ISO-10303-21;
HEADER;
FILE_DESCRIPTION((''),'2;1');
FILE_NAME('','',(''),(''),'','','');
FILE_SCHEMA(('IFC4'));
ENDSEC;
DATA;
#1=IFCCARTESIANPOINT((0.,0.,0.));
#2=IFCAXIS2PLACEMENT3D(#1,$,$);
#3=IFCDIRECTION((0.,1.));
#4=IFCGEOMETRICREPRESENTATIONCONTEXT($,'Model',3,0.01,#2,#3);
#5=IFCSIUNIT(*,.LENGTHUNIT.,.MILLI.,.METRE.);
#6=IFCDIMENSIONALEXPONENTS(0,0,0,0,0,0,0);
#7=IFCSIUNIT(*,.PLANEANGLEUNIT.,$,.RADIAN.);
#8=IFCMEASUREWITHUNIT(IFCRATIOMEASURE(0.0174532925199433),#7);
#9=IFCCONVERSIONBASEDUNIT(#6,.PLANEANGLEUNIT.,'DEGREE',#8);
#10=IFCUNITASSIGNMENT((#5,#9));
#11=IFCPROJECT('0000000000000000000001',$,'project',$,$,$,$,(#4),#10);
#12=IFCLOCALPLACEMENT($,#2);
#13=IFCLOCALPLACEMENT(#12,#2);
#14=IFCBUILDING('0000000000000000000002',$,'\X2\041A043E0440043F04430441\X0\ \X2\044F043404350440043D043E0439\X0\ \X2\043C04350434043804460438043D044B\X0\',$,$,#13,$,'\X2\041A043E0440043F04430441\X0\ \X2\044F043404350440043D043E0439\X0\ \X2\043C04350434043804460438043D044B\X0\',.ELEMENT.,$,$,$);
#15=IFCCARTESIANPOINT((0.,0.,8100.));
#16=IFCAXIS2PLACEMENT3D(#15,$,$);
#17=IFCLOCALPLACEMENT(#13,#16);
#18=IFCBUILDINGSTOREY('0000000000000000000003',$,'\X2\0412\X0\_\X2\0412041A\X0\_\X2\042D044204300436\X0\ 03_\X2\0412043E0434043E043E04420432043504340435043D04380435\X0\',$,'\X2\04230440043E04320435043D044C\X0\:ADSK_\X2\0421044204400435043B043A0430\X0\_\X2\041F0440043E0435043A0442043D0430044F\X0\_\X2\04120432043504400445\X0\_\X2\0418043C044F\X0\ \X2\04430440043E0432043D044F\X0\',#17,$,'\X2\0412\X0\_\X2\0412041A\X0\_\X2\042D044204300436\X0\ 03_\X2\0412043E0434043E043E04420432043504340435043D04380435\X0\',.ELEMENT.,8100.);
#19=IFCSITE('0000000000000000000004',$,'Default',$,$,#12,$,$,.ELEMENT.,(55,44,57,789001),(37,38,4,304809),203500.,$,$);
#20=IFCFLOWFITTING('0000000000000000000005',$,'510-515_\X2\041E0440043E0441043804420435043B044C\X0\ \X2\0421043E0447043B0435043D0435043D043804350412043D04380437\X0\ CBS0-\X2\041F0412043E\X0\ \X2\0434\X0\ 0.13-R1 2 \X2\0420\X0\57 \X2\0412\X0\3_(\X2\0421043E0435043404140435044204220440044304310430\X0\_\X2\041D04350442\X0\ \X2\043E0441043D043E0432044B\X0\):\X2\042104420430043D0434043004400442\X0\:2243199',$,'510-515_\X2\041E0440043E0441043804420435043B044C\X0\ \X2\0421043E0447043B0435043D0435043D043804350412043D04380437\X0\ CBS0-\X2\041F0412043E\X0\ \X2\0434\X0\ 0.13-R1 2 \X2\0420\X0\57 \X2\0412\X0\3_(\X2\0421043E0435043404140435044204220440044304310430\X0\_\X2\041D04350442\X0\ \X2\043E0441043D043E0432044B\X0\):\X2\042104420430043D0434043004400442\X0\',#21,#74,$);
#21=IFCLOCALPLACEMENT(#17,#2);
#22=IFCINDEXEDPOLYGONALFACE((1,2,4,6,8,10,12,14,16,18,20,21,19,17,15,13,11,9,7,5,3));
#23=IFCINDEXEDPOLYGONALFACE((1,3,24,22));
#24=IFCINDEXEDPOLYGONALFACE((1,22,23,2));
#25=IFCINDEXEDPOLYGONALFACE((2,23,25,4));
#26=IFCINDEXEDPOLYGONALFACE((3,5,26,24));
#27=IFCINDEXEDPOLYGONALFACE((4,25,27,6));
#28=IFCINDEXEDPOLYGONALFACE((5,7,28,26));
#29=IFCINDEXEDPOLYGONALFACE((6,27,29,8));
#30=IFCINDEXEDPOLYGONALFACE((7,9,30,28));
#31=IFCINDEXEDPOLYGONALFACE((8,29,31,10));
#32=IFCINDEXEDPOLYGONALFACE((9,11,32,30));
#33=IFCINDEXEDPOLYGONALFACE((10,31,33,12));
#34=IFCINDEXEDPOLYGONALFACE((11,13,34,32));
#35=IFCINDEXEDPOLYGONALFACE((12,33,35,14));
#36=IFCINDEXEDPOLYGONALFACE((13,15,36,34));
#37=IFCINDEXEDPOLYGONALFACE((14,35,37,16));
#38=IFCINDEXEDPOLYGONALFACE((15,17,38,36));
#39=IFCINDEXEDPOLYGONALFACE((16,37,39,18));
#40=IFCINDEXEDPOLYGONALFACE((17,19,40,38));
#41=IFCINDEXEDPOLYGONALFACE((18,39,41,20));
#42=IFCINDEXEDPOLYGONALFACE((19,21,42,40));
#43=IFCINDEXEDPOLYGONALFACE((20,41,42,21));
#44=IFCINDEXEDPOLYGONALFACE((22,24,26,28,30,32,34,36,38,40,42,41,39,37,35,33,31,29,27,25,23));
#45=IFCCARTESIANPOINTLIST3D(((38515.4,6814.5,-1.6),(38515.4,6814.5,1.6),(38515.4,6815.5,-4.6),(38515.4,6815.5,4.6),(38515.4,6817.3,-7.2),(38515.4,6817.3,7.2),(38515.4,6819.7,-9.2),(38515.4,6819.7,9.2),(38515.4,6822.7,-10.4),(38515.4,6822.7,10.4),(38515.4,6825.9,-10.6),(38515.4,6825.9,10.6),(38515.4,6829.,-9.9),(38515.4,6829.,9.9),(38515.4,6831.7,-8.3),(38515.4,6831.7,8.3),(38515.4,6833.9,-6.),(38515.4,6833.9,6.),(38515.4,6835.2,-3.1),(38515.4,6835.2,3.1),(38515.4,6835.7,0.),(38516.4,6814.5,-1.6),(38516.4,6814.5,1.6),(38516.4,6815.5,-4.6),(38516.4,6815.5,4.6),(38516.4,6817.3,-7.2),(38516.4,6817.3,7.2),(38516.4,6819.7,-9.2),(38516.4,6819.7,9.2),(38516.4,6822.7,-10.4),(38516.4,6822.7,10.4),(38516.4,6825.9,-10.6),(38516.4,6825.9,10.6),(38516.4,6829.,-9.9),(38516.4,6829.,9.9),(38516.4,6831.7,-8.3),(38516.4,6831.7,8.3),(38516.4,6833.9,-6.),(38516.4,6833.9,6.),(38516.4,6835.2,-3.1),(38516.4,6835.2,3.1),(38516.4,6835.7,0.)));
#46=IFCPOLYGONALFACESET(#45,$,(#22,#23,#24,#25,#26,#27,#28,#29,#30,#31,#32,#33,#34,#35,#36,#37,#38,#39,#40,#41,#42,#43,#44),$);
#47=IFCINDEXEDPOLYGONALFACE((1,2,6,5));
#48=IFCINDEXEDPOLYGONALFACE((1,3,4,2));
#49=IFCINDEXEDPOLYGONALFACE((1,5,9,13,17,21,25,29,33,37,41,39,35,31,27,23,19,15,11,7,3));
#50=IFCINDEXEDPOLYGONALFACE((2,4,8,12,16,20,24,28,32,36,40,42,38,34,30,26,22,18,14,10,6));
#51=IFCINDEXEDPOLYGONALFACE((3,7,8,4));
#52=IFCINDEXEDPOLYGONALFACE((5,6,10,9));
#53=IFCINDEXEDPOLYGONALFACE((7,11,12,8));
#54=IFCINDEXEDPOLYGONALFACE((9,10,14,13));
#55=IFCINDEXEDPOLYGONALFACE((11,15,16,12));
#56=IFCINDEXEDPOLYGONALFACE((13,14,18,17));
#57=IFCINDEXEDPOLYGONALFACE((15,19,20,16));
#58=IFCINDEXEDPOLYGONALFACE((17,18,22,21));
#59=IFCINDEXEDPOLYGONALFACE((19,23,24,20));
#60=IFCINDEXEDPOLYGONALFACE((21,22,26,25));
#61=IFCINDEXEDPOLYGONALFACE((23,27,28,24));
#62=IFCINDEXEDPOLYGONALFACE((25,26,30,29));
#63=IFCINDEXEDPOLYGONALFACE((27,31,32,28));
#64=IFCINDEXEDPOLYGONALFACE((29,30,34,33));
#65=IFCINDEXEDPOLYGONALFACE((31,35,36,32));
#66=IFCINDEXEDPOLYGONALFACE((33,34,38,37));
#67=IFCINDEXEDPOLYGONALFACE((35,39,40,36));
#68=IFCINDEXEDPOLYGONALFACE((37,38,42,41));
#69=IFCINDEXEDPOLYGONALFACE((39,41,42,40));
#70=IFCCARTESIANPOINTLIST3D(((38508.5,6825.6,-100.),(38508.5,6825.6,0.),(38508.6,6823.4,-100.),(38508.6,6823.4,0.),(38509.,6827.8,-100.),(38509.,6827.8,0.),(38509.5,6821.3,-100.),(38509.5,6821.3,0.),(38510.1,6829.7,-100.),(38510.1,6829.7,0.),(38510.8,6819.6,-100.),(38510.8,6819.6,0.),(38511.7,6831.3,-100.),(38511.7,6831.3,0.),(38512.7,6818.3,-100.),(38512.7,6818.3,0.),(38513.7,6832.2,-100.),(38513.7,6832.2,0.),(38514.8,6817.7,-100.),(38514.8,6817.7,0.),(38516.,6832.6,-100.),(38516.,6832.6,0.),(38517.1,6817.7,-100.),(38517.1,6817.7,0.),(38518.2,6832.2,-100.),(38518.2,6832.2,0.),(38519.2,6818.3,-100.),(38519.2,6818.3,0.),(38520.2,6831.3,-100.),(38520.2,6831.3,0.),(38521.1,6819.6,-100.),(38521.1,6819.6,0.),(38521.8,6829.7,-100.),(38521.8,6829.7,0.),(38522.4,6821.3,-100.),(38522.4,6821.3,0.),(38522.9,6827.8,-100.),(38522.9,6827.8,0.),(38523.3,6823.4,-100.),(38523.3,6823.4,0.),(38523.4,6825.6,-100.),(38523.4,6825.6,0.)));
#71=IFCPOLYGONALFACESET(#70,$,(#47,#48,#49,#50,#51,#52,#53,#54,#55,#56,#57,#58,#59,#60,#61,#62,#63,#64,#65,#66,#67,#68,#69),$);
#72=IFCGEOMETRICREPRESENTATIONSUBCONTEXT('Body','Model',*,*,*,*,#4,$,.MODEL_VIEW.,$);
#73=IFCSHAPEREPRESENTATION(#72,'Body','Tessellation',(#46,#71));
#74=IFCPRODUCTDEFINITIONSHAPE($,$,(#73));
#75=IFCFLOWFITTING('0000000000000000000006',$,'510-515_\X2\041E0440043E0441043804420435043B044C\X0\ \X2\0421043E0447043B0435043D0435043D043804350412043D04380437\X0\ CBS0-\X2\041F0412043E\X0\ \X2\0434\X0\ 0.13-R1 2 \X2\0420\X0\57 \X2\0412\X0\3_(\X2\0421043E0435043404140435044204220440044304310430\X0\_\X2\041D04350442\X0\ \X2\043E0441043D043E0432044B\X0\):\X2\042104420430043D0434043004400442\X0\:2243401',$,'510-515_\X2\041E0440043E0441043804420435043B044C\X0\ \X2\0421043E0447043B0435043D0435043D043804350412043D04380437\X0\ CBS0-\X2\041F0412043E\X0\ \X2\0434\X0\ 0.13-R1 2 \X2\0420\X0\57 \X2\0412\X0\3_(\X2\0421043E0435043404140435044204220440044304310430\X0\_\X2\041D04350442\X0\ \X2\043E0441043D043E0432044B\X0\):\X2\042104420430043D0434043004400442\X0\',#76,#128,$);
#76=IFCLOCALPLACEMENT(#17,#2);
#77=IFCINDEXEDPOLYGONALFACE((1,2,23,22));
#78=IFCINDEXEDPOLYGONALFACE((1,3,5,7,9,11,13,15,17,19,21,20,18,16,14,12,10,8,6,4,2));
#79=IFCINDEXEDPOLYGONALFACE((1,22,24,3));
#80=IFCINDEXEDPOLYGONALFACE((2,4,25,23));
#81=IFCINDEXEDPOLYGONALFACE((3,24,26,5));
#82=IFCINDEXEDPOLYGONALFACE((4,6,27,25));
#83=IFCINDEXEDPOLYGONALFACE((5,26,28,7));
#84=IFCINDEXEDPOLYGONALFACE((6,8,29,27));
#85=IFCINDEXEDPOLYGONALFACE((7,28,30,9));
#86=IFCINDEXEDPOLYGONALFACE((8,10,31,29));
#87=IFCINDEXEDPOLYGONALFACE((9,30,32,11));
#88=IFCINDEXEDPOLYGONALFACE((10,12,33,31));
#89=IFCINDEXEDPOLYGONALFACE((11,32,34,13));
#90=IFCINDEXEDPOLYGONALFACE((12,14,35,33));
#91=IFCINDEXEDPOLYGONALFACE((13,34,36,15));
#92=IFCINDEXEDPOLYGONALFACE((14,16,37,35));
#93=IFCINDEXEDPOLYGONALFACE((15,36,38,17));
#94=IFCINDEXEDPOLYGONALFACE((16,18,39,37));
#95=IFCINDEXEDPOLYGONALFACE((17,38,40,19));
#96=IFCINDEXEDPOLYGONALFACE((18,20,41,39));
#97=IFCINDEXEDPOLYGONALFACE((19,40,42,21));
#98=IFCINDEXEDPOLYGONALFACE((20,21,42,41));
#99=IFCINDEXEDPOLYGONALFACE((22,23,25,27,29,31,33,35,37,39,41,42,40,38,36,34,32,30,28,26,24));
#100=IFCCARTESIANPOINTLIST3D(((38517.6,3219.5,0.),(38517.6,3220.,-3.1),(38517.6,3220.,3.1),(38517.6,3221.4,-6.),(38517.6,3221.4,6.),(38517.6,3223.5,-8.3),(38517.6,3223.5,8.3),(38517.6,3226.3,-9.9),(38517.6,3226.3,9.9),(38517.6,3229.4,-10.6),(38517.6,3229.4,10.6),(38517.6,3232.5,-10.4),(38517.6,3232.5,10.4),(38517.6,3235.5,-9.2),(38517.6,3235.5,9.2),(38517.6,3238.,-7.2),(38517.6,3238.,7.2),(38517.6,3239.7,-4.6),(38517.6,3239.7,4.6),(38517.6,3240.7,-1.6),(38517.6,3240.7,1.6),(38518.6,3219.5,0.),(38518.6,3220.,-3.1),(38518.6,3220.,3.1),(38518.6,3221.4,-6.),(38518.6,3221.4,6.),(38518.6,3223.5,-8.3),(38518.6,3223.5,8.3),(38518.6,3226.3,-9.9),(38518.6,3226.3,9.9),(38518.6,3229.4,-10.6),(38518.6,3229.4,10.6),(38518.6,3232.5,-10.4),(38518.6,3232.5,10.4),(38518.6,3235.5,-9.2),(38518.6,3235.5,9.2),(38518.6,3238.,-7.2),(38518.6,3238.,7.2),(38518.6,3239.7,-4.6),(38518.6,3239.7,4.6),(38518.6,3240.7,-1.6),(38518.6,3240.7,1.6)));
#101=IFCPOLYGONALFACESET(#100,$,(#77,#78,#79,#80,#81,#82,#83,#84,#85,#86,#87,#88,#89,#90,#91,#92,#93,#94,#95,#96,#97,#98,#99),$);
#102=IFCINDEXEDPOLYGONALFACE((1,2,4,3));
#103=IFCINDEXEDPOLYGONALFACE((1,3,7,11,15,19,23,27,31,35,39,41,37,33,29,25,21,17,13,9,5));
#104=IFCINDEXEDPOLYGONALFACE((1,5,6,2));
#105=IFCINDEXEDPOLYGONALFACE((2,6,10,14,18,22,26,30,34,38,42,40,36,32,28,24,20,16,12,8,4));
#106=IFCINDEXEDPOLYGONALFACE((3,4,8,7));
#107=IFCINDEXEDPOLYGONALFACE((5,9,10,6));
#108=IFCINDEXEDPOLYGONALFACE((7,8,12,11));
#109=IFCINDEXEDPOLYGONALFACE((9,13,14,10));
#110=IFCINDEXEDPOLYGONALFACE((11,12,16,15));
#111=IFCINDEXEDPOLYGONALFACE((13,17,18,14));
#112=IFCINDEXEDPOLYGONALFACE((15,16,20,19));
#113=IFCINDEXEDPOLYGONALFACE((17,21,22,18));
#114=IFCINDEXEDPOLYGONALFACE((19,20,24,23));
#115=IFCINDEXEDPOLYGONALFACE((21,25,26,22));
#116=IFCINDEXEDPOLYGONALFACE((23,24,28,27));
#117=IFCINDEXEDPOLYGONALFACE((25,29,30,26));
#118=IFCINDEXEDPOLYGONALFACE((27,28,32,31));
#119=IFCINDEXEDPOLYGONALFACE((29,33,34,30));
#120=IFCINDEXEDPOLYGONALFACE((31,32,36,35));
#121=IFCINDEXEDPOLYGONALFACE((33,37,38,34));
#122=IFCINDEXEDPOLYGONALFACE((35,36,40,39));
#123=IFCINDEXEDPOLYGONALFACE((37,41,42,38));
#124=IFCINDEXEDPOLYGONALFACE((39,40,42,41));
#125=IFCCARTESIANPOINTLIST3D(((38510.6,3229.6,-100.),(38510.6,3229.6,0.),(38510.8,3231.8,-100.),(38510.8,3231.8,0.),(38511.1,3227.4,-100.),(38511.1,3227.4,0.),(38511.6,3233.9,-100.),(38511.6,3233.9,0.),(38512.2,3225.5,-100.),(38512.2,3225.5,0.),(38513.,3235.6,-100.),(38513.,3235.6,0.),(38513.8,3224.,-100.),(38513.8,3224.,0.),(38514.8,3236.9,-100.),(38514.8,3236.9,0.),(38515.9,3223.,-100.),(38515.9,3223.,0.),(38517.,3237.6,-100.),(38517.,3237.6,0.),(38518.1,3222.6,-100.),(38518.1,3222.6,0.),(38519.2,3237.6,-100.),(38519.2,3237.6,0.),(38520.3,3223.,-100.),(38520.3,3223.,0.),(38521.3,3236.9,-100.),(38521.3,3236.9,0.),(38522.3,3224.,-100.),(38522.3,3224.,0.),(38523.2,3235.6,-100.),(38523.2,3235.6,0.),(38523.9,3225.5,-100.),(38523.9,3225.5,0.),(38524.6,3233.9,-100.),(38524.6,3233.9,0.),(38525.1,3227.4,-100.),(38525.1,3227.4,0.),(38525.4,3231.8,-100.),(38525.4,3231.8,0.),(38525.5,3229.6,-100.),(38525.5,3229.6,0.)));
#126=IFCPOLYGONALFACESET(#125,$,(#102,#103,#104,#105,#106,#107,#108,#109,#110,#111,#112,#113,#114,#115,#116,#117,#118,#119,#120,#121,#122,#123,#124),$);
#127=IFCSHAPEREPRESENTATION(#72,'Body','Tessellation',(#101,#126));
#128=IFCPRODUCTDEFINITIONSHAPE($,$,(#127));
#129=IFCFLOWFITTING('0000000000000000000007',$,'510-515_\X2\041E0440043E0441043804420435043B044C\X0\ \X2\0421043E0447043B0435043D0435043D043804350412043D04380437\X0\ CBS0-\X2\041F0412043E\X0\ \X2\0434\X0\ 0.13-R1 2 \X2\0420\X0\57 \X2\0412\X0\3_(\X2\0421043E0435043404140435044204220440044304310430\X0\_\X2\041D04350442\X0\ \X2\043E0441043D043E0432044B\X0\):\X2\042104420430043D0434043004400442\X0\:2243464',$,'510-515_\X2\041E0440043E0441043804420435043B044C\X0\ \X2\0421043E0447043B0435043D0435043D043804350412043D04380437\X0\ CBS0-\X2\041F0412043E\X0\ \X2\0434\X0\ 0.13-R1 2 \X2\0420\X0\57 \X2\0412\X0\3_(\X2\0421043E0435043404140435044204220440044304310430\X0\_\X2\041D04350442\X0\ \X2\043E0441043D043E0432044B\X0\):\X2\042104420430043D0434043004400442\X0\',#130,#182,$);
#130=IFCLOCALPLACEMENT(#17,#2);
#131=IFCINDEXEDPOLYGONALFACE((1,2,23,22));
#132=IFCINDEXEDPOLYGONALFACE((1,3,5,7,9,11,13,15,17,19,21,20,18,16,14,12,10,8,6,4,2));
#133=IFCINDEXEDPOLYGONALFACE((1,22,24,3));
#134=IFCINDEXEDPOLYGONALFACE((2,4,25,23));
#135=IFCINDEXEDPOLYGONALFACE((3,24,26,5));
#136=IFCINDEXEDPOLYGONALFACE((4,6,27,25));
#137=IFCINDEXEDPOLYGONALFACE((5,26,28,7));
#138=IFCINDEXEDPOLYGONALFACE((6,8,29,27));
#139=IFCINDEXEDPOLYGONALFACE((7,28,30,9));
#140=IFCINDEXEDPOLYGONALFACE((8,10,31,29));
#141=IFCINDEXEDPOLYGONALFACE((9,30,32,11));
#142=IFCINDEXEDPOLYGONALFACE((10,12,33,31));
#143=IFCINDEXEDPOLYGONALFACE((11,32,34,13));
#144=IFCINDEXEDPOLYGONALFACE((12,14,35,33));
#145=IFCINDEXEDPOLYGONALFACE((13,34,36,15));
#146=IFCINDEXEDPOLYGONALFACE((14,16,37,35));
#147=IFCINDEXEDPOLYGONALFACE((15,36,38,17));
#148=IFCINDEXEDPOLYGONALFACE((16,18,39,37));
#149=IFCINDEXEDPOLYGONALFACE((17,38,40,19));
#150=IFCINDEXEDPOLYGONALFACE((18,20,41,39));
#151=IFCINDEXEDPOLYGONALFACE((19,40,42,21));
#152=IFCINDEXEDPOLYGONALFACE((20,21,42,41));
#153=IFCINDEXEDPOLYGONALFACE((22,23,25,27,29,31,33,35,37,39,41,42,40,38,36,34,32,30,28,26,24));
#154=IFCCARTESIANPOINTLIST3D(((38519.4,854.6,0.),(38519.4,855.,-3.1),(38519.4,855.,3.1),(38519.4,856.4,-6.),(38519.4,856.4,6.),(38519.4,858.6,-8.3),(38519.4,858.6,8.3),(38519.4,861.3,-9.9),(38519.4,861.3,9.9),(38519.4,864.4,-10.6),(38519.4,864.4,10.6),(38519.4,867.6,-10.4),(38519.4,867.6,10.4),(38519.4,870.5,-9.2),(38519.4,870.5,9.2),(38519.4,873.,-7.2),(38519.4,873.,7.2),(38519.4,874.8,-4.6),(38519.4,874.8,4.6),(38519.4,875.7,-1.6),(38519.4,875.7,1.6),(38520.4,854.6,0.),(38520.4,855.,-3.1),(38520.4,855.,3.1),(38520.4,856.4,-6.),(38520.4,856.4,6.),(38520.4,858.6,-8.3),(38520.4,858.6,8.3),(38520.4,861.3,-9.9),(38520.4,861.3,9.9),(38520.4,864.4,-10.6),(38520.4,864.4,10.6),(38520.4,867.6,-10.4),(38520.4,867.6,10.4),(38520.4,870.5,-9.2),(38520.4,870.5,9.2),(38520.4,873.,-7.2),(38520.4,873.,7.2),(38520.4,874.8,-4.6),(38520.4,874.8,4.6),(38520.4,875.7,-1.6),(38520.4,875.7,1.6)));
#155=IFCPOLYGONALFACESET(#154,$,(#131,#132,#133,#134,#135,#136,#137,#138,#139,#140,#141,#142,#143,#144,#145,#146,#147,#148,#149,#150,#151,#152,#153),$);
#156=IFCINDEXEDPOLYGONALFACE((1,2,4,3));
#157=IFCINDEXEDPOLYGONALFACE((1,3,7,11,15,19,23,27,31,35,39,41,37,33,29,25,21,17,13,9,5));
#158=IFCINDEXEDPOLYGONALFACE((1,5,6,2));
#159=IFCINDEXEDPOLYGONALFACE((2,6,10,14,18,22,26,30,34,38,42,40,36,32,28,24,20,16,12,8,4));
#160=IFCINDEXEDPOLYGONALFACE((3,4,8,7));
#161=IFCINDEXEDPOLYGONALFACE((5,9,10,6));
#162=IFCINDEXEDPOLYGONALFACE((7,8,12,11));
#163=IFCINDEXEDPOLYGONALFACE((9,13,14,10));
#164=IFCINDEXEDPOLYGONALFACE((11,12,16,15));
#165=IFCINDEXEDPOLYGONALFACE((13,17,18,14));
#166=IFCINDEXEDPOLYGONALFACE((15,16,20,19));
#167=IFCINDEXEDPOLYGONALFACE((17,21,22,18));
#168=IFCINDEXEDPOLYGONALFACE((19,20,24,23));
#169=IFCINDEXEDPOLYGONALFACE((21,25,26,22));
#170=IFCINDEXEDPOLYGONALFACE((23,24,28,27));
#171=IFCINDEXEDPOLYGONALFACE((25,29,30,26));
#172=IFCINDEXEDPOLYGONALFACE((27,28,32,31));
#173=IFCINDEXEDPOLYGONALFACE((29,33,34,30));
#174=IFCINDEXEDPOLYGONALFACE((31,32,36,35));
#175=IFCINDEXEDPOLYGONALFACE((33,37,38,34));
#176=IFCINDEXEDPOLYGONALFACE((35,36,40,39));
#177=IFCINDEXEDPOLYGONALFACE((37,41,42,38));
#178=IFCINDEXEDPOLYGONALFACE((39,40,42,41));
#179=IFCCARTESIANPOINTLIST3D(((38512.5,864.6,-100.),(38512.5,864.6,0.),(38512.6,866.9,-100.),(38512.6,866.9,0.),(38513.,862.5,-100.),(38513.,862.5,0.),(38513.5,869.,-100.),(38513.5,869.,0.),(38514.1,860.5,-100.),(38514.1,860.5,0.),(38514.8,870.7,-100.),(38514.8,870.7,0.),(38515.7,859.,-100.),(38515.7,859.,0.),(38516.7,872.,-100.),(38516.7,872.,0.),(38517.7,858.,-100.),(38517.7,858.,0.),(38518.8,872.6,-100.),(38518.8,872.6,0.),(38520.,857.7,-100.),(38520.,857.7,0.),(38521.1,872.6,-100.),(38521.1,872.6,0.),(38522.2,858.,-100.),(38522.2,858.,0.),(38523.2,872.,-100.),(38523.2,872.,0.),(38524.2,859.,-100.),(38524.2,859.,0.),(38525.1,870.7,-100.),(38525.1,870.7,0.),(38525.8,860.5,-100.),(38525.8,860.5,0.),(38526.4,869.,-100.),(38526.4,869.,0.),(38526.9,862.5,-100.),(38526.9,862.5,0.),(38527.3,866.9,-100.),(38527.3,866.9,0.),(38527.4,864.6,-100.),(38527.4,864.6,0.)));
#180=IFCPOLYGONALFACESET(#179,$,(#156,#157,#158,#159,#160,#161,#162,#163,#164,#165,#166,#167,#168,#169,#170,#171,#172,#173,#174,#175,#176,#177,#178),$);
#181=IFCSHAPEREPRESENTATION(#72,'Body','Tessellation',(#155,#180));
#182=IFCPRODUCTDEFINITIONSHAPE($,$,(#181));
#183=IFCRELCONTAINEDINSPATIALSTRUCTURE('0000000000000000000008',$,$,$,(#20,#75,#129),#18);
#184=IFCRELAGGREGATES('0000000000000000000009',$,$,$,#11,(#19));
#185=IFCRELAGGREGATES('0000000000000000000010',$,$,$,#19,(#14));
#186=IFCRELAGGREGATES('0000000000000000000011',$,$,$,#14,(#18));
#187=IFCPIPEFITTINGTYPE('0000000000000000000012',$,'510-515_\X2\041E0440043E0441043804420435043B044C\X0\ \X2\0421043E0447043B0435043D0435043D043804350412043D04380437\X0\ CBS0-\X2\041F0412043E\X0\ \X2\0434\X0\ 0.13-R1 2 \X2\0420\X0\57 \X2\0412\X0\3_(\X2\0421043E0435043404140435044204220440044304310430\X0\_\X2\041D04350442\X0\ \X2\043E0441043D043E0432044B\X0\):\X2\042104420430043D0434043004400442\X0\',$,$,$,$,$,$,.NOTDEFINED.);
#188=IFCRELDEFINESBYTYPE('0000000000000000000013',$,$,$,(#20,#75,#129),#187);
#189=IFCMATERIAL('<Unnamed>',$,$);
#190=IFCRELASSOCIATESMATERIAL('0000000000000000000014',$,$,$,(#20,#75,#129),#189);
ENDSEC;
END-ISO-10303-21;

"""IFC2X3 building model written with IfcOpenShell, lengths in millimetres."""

from ifc_helpers import new_model, entity, si_unit, converted_unit, direction, frame, origin, origin_2d_with_axis, place, context, subcontext, project, spatial, circle, extrude, source, transform, mapped, material, type_object, type_shapes, element, save


model = new_model("IFC2X3")

# Units and contexts
model_context = context("Model", 3, precision=0.01, world=origin(), true_north=direction((0.0, 1.0)))
body_context = subcontext(model_context, "Body", "Model", "MODEL_VIEW")
ifc_project = project(units=[si_unit("LENGTHUNIT", "METRE", prefix="MILLI"), converted_unit("PLANEANGLEUNIT", "DEGREE", entity("IfcRatioMeasure", 0.0174532925199433), si_unit("PLANEANGLEUNIT", "RADIAN"), dimensions=[0, 0, 0, 0, 0, 0, 0])], contexts=[model_context])

# Site, building, storey
site_placement = place(None, origin())
site = spatial("IfcSite", under=ifc_project, at=site_placement, Name="Default", CompositionType="ELEMENT", RefLatitude=(55, 44, 57, 789001), RefLongitude=(37, 38, 4, 304809), RefElevation=203500.0)
building_placement = place(site_placement, origin())
building = spatial("IfcBuilding", under=site, at=building_placement, Name="Корпус ядерной медицины", LongName="Корпус ядерной медицины", CompositionType="ELEMENT")
storey_placement = place(building_placement, frame((0.0, 0.0, 8100.0)))
storey = spatial("IfcBuildingStorey", under=building, at=storey_placement, Name="В_ВК_Этаж 03_Водоотведение", ObjectType="Уровень:ADSK_Стрелка_Проектная_Вверх_Имя уровня", LongName="В_ВК_Этаж 03_Водоотведение", CompositionType="ELEMENT", Elevation=8100.0)

# Flow fittings
ifc_material = material(Name="<Unnamed>")
pipe_fitting_type_1 = type_object("IfcPipeFittingType", Name="510-515_Ороситель СочленениеВниз CBS0-ПВо д 0.13-R1 2 Р57 В3_(СоедДетТруба_Нет основы):Стандарт", PredefinedType="NOTDEFINED")
shared_shape_1 = source(origin(), body_context, "Body", "SweptSolid", [
    extrude(circle(Radius=10.7, at=origin_2d_with_axis()), frame((-0.5, 0.0, 0.0), z_axis=(1.0, 0.0, 0.0), x_axis=(0.0, 1.0, 0.0)), (0.0, 0.0, 1.0), 1.0),
    extrude(circle(Radius=7.5, at=origin_2d_with_axis()), frame((0.0, 0.0, -100.0), z_axis=(0.0, 0.0, 1.0), x_axis=(0.0, 1.0, 0.0)), (0.0, 0.0, 1.0), 100.0),
])
type_shapes(pipe_fitting_type_1, [shared_shape_1])
flow_fitting_placement = place(storey_placement, frame((38515.9, 6825.1, 0.0)))
element("IfcFlowFitting", 1, at=flow_fitting_placement, inside=storey, type_object=pipe_fitting_type_1, material=ifc_material, Name="510-515_Ороситель СочленениеВниз CBS0-ПВо д 0.13-R1 2 Р57 В3_(СоедДетТруба_Нет основы):Стандарт:2243199", ObjectType="510-515_Ороситель СочленениеВниз CBS0-ПВо д 0.13-R1 2 Р57 В3_(СоедДетТруба_Нет основы):Стандарт", context=body_context, shape_type="MappedRepresentation", body=[
    mapped(shared_shape_1, transform((0.0, 0.0, 0.0), scale=1.0)),
])
for number, where, z_axis, x_axis, name in (
    (2, (38518.1, 3230.2, 0.0), (0.0, 0.0, 1.0), (-1.0, 0.0, 0.0), "510-515_Ороситель СочленениеВниз CBS0-ПВо д 0.13-R1 2 Р57 В3_(СоедДетТруба_Нет основы):Стандарт:2243401"),
    (3, (38519.9, 865.2, 0.0), (0.0, 0.0, 1.0), (-1.0, 0.0, 0.0), "510-515_Ороситель СочленениеВниз CBS0-ПВо д 0.13-R1 2 Р57 В3_(СоедДетТруба_Нет основы):Стандарт:2243464"),
):
    element("IfcFlowFitting", number, at=place(storey_placement, frame(where, z_axis=z_axis, x_axis=x_axis)), inside=storey, type_object=pipe_fitting_type_1, material=ifc_material, Name=name, ObjectType="510-515_Ороситель СочленениеВниз CBS0-ПВо д 0.13-R1 2 Р57 В3_(СоедДетТруба_Нет основы):Стандарт", context=body_context, shape_type="MappedRepresentation", body=[
        mapped(shared_shape_1, transform((0.0, 0.0, 0.0), scale=1.0)),
    ])

save(model, "model.ifc")
